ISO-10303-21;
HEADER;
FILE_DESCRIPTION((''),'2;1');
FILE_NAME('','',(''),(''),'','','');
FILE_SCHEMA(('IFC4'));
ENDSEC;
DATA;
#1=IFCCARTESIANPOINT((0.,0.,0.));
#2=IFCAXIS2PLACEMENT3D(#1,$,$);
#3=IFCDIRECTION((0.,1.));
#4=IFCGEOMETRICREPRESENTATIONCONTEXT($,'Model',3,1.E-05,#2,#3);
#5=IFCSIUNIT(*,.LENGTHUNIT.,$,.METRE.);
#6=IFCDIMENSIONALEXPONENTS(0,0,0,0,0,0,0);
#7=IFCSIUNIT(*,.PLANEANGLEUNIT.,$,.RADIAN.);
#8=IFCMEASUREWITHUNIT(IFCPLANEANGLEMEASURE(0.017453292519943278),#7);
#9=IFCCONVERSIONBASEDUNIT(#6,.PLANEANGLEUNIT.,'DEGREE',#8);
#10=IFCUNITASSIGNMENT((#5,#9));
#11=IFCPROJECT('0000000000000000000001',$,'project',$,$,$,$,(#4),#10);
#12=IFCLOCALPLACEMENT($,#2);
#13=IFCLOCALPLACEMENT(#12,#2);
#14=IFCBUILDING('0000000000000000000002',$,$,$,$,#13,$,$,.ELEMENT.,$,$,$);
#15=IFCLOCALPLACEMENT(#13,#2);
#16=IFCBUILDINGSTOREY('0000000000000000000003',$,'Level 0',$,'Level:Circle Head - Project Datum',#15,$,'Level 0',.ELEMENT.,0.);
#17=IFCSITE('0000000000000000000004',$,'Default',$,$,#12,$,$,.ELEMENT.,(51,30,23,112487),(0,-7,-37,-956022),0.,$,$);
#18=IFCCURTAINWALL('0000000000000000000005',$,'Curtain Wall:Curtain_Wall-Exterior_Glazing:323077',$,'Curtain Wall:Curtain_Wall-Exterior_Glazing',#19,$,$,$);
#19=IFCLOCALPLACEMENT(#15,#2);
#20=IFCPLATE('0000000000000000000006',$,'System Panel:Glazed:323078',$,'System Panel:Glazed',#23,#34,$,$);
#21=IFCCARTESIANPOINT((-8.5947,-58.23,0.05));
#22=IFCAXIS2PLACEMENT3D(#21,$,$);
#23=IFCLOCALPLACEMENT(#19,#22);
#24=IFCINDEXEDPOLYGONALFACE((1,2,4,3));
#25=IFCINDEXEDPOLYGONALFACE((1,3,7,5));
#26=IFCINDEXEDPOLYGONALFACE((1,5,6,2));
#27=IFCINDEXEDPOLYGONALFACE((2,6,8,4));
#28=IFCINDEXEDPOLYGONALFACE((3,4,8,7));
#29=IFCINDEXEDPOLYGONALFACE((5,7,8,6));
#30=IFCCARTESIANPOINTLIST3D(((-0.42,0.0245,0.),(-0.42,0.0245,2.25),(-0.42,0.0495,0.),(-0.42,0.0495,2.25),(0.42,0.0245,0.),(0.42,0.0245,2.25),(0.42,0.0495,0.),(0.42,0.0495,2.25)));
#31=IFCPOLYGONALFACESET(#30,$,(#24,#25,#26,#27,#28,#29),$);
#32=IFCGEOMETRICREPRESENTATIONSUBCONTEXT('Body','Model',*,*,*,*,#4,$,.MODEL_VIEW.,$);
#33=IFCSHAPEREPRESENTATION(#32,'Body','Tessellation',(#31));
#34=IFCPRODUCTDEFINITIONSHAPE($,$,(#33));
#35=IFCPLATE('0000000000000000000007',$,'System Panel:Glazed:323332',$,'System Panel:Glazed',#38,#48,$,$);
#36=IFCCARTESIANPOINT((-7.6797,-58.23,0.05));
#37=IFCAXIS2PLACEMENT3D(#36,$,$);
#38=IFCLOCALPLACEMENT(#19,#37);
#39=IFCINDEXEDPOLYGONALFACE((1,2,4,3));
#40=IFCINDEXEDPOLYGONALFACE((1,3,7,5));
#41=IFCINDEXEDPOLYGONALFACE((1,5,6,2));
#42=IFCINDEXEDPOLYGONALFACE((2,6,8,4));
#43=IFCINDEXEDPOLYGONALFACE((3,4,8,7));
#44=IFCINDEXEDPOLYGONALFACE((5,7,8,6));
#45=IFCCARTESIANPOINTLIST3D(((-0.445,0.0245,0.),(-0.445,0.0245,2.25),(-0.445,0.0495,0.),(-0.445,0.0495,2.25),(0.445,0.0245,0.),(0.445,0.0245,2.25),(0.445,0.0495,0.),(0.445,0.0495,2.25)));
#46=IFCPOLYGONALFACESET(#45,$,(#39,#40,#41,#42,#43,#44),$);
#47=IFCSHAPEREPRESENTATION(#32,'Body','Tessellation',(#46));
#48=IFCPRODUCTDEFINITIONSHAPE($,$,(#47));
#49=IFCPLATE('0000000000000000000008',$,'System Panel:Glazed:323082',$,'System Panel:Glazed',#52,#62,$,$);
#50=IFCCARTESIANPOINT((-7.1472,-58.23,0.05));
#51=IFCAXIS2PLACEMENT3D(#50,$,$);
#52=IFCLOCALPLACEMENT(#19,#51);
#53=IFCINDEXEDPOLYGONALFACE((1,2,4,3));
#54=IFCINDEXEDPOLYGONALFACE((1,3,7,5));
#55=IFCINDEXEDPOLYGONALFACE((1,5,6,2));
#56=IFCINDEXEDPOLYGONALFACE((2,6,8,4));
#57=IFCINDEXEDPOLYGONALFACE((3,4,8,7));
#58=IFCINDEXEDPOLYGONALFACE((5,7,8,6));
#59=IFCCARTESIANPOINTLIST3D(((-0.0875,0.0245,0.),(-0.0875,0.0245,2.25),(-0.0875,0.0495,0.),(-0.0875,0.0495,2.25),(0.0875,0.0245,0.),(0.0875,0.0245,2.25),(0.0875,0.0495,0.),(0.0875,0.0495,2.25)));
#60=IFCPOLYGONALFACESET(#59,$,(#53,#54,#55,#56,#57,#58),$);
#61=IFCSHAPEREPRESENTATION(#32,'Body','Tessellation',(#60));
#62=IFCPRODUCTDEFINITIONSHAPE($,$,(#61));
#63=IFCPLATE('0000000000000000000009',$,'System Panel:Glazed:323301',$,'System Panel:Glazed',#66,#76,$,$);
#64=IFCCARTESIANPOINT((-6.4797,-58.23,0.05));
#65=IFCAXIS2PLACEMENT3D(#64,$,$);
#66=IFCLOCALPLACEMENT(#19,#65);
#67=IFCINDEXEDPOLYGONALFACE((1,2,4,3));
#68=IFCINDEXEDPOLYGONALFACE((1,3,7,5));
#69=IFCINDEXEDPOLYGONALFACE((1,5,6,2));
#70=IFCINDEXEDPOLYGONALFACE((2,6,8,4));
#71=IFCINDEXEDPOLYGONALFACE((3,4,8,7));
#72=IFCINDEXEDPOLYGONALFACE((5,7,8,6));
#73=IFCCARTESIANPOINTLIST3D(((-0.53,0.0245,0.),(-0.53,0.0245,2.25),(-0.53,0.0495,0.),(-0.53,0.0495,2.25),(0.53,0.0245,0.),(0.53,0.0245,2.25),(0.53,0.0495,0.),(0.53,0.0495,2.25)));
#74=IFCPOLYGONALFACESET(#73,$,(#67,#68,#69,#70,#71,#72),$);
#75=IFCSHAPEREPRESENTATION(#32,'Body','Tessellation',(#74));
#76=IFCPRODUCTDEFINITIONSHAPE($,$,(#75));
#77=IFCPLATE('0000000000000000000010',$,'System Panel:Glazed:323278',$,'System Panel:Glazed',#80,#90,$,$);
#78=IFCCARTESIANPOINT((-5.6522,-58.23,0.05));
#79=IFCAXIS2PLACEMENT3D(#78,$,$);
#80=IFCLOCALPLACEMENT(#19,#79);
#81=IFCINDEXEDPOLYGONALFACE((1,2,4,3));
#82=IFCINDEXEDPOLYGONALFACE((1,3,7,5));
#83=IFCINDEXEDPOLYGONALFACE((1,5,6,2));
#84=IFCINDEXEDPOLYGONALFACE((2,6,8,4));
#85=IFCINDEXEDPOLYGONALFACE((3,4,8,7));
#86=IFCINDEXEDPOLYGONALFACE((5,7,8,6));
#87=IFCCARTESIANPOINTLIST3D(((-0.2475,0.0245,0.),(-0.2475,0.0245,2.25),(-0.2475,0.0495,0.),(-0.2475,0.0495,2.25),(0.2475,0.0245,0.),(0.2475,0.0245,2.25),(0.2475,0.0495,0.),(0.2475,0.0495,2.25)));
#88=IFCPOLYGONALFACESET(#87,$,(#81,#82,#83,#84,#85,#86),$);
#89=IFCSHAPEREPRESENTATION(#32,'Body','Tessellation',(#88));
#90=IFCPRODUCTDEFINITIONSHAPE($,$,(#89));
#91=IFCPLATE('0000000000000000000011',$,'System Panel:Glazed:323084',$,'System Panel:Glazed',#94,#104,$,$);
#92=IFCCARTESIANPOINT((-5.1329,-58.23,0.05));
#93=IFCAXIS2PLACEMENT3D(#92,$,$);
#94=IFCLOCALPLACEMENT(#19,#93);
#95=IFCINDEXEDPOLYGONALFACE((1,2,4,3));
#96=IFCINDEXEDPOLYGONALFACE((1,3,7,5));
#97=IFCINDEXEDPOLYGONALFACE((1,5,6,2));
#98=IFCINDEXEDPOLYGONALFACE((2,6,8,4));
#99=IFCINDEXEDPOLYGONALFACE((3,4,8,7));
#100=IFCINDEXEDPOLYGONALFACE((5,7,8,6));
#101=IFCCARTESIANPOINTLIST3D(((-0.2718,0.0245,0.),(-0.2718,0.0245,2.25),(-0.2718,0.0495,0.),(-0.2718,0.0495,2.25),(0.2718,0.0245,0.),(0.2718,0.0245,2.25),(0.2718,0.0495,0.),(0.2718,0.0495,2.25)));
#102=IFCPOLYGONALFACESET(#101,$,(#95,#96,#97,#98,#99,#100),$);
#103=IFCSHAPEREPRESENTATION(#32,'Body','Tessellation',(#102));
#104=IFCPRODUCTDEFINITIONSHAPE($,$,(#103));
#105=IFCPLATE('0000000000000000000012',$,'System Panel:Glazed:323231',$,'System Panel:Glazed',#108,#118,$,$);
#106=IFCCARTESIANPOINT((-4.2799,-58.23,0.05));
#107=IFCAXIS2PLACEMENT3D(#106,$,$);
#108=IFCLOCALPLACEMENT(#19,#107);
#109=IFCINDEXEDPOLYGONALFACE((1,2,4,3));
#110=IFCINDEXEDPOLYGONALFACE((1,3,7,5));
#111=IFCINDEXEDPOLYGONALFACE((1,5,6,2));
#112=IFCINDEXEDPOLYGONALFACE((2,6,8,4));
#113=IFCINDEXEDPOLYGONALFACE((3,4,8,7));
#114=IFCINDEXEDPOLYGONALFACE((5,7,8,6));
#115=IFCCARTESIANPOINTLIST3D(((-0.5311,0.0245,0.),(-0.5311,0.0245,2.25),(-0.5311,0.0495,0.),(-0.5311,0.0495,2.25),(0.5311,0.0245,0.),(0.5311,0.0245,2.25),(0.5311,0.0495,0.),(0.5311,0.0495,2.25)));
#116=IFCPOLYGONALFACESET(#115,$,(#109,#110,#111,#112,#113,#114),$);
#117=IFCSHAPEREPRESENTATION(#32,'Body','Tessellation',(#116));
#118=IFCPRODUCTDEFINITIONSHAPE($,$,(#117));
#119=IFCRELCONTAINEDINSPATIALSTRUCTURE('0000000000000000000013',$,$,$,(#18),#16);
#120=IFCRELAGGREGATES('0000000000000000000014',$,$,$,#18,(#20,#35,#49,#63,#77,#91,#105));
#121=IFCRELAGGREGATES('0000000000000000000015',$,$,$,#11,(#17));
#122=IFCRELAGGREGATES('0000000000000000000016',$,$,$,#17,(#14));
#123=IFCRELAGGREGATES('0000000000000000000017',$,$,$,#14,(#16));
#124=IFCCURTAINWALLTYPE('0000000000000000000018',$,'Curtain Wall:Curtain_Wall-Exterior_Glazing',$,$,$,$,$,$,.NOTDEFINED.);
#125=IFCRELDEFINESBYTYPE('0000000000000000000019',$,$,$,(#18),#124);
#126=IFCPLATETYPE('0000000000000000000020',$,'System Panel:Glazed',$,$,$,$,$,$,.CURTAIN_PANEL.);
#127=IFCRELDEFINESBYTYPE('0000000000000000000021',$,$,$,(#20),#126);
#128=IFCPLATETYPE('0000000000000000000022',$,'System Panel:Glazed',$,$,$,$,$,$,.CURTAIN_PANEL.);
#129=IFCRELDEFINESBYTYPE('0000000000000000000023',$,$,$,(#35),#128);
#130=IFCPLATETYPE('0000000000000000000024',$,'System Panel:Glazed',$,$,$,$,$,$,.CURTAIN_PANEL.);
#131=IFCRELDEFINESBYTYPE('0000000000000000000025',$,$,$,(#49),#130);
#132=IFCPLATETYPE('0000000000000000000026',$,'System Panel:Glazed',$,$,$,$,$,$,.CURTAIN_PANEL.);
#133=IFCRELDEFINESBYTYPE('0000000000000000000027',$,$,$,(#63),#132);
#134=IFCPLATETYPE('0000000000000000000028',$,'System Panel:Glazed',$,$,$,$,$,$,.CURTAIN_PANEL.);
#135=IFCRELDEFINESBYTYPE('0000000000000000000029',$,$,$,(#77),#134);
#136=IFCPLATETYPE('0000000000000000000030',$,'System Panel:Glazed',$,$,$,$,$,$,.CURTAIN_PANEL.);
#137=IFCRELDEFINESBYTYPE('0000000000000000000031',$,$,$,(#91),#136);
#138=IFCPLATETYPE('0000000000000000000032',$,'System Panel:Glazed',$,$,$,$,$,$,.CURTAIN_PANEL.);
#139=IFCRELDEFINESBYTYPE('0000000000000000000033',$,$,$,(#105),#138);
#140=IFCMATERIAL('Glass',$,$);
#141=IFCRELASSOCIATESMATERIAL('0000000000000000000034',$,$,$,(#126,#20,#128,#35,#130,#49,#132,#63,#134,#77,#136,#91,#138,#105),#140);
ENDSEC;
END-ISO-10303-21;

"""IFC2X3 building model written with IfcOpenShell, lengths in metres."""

from ifc_helpers import new_model, entity, si_unit, converted_unit, direction, frame, origin, origin_2d_with_axis, place, context, subcontext, project, spatial, rectangle, extrude, source, transform, mapped, material, type_object, type_shapes, element, aggregate, save


model = new_model("IFC2X3")

# Units and contexts
model_context = context("Model", 3, precision=1e-05, world=origin(), true_north=direction((0.0, 1.0)))
body_context = subcontext(model_context, "Body", "Model", "MODEL_VIEW")
ifc_project = project(units=[si_unit("LENGTHUNIT", "METRE"), converted_unit("PLANEANGLEUNIT", "DEGREE", entity("IfcPlaneAngleMeasure", 0.017453292519943278), si_unit("PLANEANGLEUNIT", "RADIAN"), dimensions=[0, 0, 0, 0, 0, 0, 0])], contexts=[model_context])

# Site, building, storey
site_placement = place(None, origin())
site = spatial("IfcSite", under=ifc_project, at=site_placement, Name="Default", CompositionType="ELEMENT", RefLatitude=(51, 30, 23, 112487), RefLongitude=(0, -7, -37, -956022), RefElevation=0.0)
building_placement = place(site_placement, origin())
building = spatial("IfcBuilding", under=site, at=building_placement, CompositionType="ELEMENT")
storey_placement = place(building_placement, origin())
storey = spatial("IfcBuildingStorey", under=building, at=storey_placement, Name="Level 0", ObjectType="Level:Circle Head - Project Datum", LongName="Level 0", CompositionType="ELEMENT", Elevation=0.0)

# Curtain wall, plates
curtain_wall_type = type_object("IfcCurtainWallType", Name="Curtain Wall:Curtain_Wall-Exterior_Glazing", PredefinedType="NOTDEFINED")
curtain_wall_placement = place(storey_placement, origin())
curtain_wall = element("IfcCurtainWall", 1, at=curtain_wall_placement, inside=storey, type_object=curtain_wall_type, Name="Curtain Wall:Curtain_Wall-Exterior_Glazing:323077", ObjectType="Curtain Wall:Curtain_Wall-Exterior_Glazing")
ifc_material_1 = material(Name="Glass")
plate_type_1 = type_object("IfcPlateType", Name="System Panel:Glazed", PredefinedType="CURTAIN_PANEL", material=ifc_material_1)
shared_shape_1 = source(origin(), body_context, "Body", "SweptSolid", [
    extrude(rectangle(XDim=0.025, YDim=0.84, at=origin_2d_with_axis()), frame((0.0, 0.037, 0.0), z_axis=(0.0, 0.0, 1.0), x_axis=(0.0, 1.0, 0.0)), (0.0, 0.0, 1.0), 2.25),
])
type_shapes(plate_type_1, [shared_shape_1])
plate_1_placement = place(curtain_wall_placement, frame((-8.5947, -58.23, 0.05)))
plate_1 = element("IfcPlate", 2, at=plate_1_placement, type_object=plate_type_1, material=ifc_material_1, Name="System Panel:Glazed:323078", ObjectType="System Panel:Glazed", context=body_context, shape_type="MappedRepresentation", body=[
    mapped(shared_shape_1, transform((0.0, 0.0, 0.0), scale=1.0)),
])
plate_type_2 = type_object("IfcPlateType", Name="System Panel:Glazed", PredefinedType="CURTAIN_PANEL", material=ifc_material_1)
shared_shape_2 = source(origin(), body_context, "Body", "SweptSolid", [
    extrude(rectangle(XDim=0.025, YDim=0.89, at=origin_2d_with_axis()), frame((0.0, 0.037, 0.0), z_axis=(0.0, 0.0, 1.0), x_axis=(0.0, 1.0, 0.0)), (0.0, 0.0, 1.0), 2.25),
])
type_shapes(plate_type_2, [shared_shape_2])
plate_2_placement = place(curtain_wall_placement, frame((-7.6797, -58.23, 0.05)))
plate_2 = element("IfcPlate", 3, at=plate_2_placement, type_object=plate_type_2, material=ifc_material_1, Name="System Panel:Glazed:323332", ObjectType="System Panel:Glazed", context=body_context, shape_type="MappedRepresentation", body=[
    mapped(shared_shape_2, transform((0.0, 0.0, 0.0), scale=1.0)),
])
plate_type_3 = type_object("IfcPlateType", Name="System Panel:Glazed", PredefinedType="CURTAIN_PANEL", material=ifc_material_1)
shared_shape_3 = source(origin(), body_context, "Body", "SweptSolid", [
    extrude(rectangle(XDim=0.025, YDim=0.175, at=origin_2d_with_axis()), frame((0.0, 0.037, 0.0), z_axis=(0.0, 0.0, 1.0), x_axis=(0.0, 1.0, 0.0)), (0.0, 0.0, 1.0), 2.25),
])
type_shapes(plate_type_3, [shared_shape_3])
plate_3_placement = place(curtain_wall_placement, frame((-7.1472, -58.23, 0.05)))
plate_3 = element("IfcPlate", 4, at=plate_3_placement, type_object=plate_type_3, material=ifc_material_1, Name="System Panel:Glazed:323082", ObjectType="System Panel:Glazed", context=body_context, shape_type="MappedRepresentation", body=[
    mapped(shared_shape_3, transform((0.0, 0.0, 0.0), scale=1.0)),
])
plate_type_4 = type_object("IfcPlateType", Name="System Panel:Glazed", PredefinedType="CURTAIN_PANEL", material=ifc_material_1)
shared_shape_4 = source(origin(), body_context, "Body", "SweptSolid", [
    extrude(rectangle(XDim=0.025, YDim=1.06, at=origin_2d_with_axis()), frame((0.0, 0.037, 0.0), z_axis=(0.0, 0.0, 1.0), x_axis=(0.0, 1.0, 0.0)), (0.0, 0.0, 1.0), 2.25),
])
type_shapes(plate_type_4, [shared_shape_4])
plate_4_placement = place(curtain_wall_placement, frame((-6.4797, -58.23, 0.05)))
plate_4 = element("IfcPlate", 5, at=plate_4_placement, type_object=plate_type_4, material=ifc_material_1, Name="System Panel:Glazed:323301", ObjectType="System Panel:Glazed", context=body_context, shape_type="MappedRepresentation", body=[
    mapped(shared_shape_4, transform((0.0, 0.0, 0.0), scale=1.0)),
])
plate_type_5 = type_object("IfcPlateType", Name="System Panel:Glazed", PredefinedType="CURTAIN_PANEL", material=ifc_material_1)
shared_shape_5 = source(origin(), body_context, "Body", "SweptSolid", [
    extrude(rectangle(XDim=0.025, YDim=0.495, at=origin_2d_with_axis()), frame((0.0, 0.037, 0.0), z_axis=(0.0, 0.0, 1.0), x_axis=(0.0, 1.0, 0.0)), (0.0, 0.0, 1.0), 2.25),
])
type_shapes(plate_type_5, [shared_shape_5])
plate_5_placement = place(curtain_wall_placement, frame((-5.6522, -58.23, 0.05)))
plate_5 = element("IfcPlate", 6, at=plate_5_placement, type_object=plate_type_5, material=ifc_material_1, Name="System Panel:Glazed:323278", ObjectType="System Panel:Glazed", context=body_context, shape_type="MappedRepresentation", body=[
    mapped(shared_shape_5, transform((0.0, 0.0, 0.0), scale=1.0)),
])
plate_type_6 = type_object("IfcPlateType", Name="System Panel:Glazed", PredefinedType="CURTAIN_PANEL", material=ifc_material_1)
shared_shape_6 = source(origin(), body_context, "Body", "SweptSolid", [
    extrude(rectangle(XDim=0.025, YDim=0.5436, at=origin_2d_with_axis()), frame((0.0, 0.037, 0.0), z_axis=(0.0, 0.0, 1.0), x_axis=(0.0, 1.0, 0.0)), (0.0, 0.0, 1.0), 2.25),
])
type_shapes(plate_type_6, [shared_shape_6])
plate_6_placement = place(curtain_wall_placement, frame((-5.1329, -58.23, 0.05)))
plate_6 = element("IfcPlate", 7, at=plate_6_placement, type_object=plate_type_6, material=ifc_material_1, Name="System Panel:Glazed:323084", ObjectType="System Panel:Glazed", context=body_context, shape_type="MappedRepresentation", body=[
    mapped(shared_shape_6, transform((0.0, 0.0, 0.0), scale=1.0)),
])
plate_type_7 = type_object("IfcPlateType", Name="System Panel:Glazed", PredefinedType="CURTAIN_PANEL", material=ifc_material_1)
shared_shape_7 = source(origin(), body_context, "Body", "SweptSolid", [
    extrude(rectangle(XDim=0.025, YDim=1.0623, at=origin_2d_with_axis()), frame((0.0, 0.037, 0.0), z_axis=(0.0, 0.0, 1.0), x_axis=(0.0, 1.0, 0.0)), (0.0, 0.0, 1.0), 2.25),
])
type_shapes(plate_type_7, [shared_shape_7])
plate_7_placement = place(curtain_wall_placement, frame((-4.2799, -58.23, 0.05)))
plate_7 = element("IfcPlate", 8, at=plate_7_placement, type_object=plate_type_7, material=ifc_material_1, Name="System Panel:Glazed:323231", ObjectType="System Panel:Glazed", context=body_context, shape_type="MappedRepresentation", body=[
    mapped(shared_shape_7, transform((0.0, 0.0, 0.0), scale=1.0)),
])
aggregate(curtain_wall, [plate_1, plate_2, plate_3, plate_4, plate_5, plate_6, plate_7])

save(model, "model.ifc")
